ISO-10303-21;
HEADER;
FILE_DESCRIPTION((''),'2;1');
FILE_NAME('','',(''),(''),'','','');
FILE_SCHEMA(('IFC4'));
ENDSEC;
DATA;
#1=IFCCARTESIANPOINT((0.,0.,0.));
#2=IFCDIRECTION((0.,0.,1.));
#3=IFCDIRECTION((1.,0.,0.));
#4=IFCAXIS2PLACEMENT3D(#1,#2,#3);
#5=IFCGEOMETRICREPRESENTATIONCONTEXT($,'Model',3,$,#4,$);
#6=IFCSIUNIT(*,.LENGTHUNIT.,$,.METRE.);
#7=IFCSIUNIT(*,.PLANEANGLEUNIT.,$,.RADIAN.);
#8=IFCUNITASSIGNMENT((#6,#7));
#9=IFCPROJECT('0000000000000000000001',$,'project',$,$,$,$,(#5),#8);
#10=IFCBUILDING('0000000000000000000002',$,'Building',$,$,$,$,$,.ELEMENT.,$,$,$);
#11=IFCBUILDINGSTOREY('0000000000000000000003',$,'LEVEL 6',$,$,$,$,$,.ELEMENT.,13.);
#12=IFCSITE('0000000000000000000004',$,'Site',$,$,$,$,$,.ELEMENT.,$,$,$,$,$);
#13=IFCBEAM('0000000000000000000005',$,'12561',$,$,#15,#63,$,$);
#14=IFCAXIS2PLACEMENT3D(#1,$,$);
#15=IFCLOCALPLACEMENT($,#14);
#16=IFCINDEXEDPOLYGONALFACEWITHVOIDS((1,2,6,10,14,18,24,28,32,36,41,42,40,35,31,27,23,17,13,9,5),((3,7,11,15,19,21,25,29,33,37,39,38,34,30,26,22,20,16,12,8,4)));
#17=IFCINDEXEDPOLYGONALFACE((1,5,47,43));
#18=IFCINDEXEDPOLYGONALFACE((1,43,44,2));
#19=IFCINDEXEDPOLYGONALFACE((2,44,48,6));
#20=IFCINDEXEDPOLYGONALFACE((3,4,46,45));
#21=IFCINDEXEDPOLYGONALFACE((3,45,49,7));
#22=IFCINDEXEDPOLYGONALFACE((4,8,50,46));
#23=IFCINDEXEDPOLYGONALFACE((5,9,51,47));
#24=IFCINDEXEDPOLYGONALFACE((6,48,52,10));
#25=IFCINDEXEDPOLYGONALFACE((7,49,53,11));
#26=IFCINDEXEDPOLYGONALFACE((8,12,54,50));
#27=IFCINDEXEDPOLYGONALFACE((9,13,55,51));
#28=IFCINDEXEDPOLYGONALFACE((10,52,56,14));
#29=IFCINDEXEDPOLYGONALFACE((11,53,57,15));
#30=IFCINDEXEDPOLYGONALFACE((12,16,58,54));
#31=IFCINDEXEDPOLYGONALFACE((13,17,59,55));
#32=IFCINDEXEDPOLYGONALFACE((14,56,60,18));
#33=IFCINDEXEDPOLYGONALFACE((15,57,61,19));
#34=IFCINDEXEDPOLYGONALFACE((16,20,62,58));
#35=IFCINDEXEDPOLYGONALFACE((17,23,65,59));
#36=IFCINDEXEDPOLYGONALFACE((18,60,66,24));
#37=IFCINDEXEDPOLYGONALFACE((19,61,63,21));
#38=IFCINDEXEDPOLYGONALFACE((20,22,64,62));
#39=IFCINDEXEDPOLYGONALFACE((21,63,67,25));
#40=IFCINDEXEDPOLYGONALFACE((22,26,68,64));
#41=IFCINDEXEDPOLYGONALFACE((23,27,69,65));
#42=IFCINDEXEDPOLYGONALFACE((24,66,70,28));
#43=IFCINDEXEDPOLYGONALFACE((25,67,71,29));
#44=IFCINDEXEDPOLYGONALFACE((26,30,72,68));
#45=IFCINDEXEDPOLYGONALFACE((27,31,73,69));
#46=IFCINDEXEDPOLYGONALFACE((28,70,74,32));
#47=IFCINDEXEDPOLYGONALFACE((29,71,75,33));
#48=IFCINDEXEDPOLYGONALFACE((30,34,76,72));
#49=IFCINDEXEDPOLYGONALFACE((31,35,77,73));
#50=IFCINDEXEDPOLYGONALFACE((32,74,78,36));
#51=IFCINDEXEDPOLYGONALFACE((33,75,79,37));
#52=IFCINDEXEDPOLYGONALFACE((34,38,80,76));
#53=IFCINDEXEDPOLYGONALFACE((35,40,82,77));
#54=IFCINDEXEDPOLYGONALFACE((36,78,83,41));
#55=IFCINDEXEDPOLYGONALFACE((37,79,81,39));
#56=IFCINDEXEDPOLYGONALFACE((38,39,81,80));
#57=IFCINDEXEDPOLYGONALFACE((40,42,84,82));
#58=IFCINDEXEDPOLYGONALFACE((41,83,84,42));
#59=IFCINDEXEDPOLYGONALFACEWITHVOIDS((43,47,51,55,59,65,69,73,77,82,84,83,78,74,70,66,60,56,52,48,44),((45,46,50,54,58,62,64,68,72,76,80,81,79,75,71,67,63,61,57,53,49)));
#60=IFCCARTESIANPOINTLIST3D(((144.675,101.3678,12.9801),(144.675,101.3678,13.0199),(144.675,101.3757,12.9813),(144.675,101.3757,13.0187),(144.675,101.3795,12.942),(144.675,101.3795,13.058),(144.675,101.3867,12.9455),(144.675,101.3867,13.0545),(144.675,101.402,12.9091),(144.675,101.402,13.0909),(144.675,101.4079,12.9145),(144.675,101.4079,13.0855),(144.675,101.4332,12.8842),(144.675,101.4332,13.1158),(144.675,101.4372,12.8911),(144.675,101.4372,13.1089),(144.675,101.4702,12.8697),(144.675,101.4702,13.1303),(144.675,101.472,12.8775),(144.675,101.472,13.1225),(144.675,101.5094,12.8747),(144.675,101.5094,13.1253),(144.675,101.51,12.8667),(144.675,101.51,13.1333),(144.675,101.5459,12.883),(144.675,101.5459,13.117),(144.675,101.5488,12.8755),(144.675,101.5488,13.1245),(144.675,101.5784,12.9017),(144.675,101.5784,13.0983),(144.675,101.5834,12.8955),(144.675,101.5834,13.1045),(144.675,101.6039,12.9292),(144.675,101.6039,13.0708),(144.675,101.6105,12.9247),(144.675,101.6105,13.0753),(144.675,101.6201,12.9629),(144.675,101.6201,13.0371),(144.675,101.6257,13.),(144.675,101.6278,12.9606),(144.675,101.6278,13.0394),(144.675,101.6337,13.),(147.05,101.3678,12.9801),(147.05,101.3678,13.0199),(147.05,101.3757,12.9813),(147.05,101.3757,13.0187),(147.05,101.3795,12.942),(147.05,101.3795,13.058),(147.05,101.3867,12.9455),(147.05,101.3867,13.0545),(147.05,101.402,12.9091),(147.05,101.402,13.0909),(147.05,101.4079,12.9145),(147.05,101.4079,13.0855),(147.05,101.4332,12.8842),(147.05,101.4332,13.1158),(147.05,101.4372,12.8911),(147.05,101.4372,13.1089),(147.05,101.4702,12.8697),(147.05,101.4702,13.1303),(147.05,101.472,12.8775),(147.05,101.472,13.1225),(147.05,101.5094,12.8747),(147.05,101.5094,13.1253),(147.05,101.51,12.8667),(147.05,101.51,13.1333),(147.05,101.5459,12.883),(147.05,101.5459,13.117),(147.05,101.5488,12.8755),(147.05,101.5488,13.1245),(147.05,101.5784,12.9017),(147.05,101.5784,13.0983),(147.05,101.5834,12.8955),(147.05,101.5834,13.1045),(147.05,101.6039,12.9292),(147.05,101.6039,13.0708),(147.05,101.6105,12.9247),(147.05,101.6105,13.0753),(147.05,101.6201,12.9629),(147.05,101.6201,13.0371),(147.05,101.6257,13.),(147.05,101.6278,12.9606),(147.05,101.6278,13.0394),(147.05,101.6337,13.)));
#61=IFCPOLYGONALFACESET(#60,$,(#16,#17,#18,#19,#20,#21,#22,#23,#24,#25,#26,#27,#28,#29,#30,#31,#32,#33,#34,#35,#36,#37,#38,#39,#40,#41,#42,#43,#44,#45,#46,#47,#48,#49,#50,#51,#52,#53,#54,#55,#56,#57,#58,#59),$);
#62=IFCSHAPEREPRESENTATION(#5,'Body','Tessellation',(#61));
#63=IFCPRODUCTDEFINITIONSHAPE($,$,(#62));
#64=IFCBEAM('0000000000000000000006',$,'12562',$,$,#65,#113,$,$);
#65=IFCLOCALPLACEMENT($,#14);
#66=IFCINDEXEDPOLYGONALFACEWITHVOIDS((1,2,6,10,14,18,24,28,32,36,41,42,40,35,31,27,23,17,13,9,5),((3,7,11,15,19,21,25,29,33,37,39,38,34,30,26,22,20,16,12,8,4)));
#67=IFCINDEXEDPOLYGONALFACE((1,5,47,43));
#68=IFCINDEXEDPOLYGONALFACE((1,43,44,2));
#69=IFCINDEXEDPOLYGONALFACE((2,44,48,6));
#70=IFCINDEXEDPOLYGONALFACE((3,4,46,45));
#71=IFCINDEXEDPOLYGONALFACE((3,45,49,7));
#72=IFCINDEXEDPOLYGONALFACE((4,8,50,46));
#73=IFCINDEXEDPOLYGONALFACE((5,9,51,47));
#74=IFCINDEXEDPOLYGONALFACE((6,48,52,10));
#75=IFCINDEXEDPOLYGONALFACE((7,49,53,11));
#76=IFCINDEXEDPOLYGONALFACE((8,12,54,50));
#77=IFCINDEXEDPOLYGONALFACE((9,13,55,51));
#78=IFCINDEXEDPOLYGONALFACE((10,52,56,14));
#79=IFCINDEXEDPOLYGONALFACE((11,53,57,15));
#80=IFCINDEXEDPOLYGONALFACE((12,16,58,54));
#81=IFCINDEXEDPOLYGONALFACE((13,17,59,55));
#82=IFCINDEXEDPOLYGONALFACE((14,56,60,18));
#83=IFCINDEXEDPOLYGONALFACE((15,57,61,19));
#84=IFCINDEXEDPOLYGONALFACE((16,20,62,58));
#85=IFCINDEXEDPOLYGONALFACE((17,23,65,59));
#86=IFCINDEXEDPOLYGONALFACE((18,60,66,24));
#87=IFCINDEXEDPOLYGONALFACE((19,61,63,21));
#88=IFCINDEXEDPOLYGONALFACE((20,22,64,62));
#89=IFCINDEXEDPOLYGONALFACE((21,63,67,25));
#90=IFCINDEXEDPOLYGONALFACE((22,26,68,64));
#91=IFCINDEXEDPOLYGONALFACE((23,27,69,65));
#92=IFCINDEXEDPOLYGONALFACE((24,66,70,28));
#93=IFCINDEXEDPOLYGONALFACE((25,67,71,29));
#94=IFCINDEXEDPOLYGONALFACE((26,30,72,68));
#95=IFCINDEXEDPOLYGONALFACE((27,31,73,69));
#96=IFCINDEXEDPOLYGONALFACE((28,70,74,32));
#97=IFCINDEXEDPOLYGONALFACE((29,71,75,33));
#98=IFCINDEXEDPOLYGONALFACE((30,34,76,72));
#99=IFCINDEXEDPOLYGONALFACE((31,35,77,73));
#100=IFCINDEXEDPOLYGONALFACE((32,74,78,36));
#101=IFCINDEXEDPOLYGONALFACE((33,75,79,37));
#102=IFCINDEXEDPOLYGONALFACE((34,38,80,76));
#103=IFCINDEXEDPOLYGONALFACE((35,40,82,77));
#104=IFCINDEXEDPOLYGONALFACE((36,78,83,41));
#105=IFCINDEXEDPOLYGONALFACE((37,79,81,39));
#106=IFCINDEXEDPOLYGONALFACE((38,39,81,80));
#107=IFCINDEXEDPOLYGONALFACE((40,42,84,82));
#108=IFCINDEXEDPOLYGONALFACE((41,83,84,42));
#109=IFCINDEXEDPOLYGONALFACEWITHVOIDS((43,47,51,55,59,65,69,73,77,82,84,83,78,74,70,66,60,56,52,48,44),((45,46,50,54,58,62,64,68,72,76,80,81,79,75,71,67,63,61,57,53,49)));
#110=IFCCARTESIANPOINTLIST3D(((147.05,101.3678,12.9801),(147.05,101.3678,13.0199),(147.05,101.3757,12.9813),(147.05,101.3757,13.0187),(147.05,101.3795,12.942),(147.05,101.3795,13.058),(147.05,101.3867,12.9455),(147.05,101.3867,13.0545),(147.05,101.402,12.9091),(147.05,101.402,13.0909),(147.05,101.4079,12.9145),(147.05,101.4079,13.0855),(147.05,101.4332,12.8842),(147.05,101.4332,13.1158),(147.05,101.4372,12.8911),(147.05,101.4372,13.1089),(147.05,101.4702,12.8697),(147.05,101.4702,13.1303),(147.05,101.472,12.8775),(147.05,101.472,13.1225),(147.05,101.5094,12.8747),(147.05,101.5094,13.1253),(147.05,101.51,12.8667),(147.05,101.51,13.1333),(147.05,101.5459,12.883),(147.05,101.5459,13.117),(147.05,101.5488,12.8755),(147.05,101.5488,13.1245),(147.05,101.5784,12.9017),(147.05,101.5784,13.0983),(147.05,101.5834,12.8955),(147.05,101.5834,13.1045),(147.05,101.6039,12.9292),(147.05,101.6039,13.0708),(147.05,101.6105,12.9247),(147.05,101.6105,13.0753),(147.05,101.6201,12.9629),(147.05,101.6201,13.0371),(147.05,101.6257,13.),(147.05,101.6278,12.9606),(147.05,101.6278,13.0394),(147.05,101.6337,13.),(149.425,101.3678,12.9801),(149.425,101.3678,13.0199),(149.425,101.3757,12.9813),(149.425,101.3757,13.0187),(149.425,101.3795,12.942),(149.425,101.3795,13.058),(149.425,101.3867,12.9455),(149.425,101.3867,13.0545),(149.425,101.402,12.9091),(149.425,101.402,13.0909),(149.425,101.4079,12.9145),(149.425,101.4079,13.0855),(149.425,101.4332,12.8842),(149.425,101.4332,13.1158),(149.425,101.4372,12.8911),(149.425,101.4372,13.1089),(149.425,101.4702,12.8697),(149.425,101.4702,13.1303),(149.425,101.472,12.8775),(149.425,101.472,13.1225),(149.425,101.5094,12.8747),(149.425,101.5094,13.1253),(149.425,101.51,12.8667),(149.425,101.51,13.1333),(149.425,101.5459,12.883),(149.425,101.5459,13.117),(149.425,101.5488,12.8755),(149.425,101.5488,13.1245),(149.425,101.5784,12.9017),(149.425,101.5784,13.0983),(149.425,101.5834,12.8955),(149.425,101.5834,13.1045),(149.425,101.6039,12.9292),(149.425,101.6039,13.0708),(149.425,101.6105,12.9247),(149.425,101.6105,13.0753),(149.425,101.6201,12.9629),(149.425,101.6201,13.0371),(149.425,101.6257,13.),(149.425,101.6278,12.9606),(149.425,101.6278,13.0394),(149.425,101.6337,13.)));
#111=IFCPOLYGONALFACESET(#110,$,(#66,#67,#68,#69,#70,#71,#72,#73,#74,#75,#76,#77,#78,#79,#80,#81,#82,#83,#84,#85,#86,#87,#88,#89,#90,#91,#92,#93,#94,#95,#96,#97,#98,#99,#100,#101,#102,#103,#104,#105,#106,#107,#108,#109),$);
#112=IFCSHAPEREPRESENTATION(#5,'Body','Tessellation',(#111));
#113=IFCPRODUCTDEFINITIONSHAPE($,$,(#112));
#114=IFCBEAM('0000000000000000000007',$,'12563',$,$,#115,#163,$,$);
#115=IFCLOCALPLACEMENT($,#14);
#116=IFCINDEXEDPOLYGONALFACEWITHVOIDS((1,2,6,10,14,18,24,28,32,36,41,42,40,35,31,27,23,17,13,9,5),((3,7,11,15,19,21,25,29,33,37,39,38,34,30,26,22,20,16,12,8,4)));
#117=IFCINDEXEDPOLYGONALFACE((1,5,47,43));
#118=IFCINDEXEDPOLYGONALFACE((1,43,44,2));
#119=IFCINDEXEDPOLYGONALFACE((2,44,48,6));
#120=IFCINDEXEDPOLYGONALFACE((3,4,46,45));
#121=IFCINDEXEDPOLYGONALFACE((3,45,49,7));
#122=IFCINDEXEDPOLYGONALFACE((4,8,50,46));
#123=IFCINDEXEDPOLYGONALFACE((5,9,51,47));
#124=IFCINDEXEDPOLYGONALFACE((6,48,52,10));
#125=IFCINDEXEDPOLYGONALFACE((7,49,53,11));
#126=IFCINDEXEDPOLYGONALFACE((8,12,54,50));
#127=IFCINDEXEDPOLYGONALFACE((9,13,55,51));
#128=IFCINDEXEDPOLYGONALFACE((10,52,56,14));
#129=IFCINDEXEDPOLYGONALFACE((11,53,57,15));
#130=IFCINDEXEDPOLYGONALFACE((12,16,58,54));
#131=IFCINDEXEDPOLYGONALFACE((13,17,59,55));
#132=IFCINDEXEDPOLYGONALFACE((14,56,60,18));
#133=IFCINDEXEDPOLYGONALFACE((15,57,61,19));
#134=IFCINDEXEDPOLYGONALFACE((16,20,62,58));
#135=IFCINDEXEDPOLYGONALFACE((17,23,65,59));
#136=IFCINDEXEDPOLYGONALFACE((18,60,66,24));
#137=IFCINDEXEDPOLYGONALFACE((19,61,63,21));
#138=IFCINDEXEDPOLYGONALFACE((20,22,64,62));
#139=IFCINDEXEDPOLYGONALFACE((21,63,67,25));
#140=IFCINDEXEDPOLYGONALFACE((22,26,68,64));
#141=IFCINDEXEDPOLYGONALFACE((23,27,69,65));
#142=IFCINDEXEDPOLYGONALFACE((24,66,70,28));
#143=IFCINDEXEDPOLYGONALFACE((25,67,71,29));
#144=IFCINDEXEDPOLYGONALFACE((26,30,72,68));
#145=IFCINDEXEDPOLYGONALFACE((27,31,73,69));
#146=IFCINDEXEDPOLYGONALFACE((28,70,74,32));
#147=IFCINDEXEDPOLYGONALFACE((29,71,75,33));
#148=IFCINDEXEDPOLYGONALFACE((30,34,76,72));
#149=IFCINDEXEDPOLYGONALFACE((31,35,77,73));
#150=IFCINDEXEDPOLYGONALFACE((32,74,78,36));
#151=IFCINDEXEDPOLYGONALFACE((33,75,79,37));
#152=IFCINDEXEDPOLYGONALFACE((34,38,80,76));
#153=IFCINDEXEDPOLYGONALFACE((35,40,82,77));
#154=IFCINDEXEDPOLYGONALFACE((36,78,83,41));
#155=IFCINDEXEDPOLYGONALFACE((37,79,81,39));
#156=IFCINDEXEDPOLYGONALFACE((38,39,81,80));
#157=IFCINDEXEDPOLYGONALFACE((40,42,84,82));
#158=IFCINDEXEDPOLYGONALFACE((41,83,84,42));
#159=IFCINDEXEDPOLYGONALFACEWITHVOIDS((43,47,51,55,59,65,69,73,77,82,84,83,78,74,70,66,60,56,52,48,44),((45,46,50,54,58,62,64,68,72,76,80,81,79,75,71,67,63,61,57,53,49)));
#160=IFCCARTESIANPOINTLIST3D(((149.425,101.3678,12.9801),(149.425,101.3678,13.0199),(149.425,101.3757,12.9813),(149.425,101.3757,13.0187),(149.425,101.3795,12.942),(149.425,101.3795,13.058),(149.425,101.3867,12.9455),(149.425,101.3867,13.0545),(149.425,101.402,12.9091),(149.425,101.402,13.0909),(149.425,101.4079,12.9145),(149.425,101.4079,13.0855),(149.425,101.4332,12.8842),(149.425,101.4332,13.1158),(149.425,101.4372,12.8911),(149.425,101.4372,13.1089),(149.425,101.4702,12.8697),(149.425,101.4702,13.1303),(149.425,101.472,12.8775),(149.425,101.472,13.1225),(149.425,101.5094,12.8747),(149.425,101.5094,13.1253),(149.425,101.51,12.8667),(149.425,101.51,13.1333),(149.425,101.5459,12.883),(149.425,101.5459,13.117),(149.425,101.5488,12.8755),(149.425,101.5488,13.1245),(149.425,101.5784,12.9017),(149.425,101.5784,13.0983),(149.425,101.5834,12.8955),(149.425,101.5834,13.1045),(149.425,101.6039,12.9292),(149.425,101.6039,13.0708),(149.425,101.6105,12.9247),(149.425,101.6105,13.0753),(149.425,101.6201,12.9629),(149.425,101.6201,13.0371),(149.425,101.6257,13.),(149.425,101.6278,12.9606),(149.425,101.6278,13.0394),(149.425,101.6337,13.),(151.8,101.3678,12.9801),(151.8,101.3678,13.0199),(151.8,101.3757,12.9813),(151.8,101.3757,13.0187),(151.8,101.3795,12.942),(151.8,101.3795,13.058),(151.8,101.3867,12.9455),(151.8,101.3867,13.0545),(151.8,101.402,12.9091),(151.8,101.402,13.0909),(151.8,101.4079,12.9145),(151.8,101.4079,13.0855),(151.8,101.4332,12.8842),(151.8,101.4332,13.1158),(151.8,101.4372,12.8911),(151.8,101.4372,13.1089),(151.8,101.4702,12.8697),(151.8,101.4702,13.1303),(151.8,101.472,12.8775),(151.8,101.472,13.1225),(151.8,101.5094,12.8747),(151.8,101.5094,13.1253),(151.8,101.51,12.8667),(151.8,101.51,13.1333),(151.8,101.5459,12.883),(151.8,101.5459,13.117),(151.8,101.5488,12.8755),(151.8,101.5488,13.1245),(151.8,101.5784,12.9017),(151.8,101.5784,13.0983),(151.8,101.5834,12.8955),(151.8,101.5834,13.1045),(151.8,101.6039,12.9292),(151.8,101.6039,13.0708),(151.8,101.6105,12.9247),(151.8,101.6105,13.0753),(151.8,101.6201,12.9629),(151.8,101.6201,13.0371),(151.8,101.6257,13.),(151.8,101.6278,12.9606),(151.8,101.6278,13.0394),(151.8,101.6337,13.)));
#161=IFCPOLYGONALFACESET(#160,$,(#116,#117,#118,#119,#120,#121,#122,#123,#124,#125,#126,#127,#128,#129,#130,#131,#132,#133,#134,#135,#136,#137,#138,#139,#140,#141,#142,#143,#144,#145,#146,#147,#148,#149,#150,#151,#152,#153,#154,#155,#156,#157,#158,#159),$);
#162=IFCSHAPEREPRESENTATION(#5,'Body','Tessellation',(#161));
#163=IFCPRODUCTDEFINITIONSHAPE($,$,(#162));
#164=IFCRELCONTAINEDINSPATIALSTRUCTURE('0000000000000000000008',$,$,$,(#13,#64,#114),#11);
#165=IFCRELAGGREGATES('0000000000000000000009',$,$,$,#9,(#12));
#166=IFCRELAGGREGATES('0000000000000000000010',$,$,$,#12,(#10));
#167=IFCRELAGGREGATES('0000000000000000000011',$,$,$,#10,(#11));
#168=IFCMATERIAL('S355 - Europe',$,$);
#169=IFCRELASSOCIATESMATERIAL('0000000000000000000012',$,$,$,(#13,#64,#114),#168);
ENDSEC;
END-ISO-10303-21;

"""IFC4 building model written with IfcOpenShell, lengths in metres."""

from ifc_helpers import new_model, si_unit, frame, origin_with_axes, origin_2d_with_axis, place, context, project, spatial, hollow_circle, extrude, material, material_profile, profile_set, profile_usage, element, save


model = new_model("IFC4")

# Units and contexts
model_context = context("Model", 3, world=origin_with_axes())
ifc_project = project(units=[si_unit("LENGTHUNIT", "METRE"), si_unit("PLANEANGLEUNIT", "RADIAN")], contexts=[model_context])

# Site, building, storey
site = spatial("IfcSite", under=ifc_project, Name="Site", CompositionType="ELEMENT")
building = spatial("IfcBuilding", under=site, Name="Building", CompositionType="ELEMENT")
storey = spatial("IfcBuildingStorey", under=building, Name="LEVEL 6", CompositionType="ELEMENT", Elevation=13.0)

# Shared definitions
ifc_material = material(Name="S355 - Europe")

# Beams
ifc_material_profile_1 = material_profile(ifc_material, hollow_circle(Radius=0.1337, WallThickness=0.008, at=origin_2d_with_axis()))
ifc_profile_set_1 = profile_set([ifc_material_profile_1])
ifc_profile_usage_1 = profile_usage(ifc_profile_set_1, cardinal=10)
beam_1_placement = place(None, frame((144.675, 101.5, 13.0), z_axis=(1.0, 0.0, 0.0), x_axis=(0.0, 1.0, 0.0)))
element("IfcBeam", 1, at=beam_1_placement, inside=storey, material=ifc_profile_usage_1, Name="12561", context=model_context, shape_type="SweptSolid", body=[
    extrude(hollow_circle(Radius=0.1337, WallThickness=0.008, at=origin_2d_with_axis()), origin_with_axes(), (0.0, 0.0, 1.0), 2.375),
])
ifc_material_profile_2 = material_profile(ifc_material, hollow_circle(Radius=0.1337, WallThickness=0.008, at=origin_2d_with_axis()))
ifc_profile_set_2 = profile_set([ifc_material_profile_2])
ifc_profile_usage_2 = profile_usage(ifc_profile_set_2, cardinal=10)
beam_2_placement = place(None, frame((147.05, 101.5, 13.0), z_axis=(1.0, 0.0, 0.0), x_axis=(0.0, 1.0, 0.0)))
element("IfcBeam", 2, at=beam_2_placement, inside=storey, material=ifc_profile_usage_2, Name="12562", context=model_context, shape_type="SweptSolid", body=[
    extrude(hollow_circle(Radius=0.1337, WallThickness=0.008, at=origin_2d_with_axis()), origin_with_axes(), (0.0, 0.0, 1.0), 2.375),
])
ifc_material_profile_3 = material_profile(ifc_material, hollow_circle(Radius=0.1337, WallThickness=0.008, at=origin_2d_with_axis()))
ifc_profile_set_3 = profile_set([ifc_material_profile_3])
ifc_profile_usage_3 = profile_usage(ifc_profile_set_3, cardinal=10)
beam_3_placement = place(None, frame((149.425, 101.5, 13.0), z_axis=(1.0, 0.0, 0.0), x_axis=(0.0, 1.0, 0.0)))
element("IfcBeam", 3, at=beam_3_placement, inside=storey, material=ifc_profile_usage_3, Name="12563", context=model_context, shape_type="SweptSolid", body=[
    extrude(hollow_circle(Radius=0.1337, WallThickness=0.008, at=origin_2d_with_axis()), origin_with_axes(), (0.0, 0.0, 1.0), 2.375),
])

save(model, "model.ifc")
